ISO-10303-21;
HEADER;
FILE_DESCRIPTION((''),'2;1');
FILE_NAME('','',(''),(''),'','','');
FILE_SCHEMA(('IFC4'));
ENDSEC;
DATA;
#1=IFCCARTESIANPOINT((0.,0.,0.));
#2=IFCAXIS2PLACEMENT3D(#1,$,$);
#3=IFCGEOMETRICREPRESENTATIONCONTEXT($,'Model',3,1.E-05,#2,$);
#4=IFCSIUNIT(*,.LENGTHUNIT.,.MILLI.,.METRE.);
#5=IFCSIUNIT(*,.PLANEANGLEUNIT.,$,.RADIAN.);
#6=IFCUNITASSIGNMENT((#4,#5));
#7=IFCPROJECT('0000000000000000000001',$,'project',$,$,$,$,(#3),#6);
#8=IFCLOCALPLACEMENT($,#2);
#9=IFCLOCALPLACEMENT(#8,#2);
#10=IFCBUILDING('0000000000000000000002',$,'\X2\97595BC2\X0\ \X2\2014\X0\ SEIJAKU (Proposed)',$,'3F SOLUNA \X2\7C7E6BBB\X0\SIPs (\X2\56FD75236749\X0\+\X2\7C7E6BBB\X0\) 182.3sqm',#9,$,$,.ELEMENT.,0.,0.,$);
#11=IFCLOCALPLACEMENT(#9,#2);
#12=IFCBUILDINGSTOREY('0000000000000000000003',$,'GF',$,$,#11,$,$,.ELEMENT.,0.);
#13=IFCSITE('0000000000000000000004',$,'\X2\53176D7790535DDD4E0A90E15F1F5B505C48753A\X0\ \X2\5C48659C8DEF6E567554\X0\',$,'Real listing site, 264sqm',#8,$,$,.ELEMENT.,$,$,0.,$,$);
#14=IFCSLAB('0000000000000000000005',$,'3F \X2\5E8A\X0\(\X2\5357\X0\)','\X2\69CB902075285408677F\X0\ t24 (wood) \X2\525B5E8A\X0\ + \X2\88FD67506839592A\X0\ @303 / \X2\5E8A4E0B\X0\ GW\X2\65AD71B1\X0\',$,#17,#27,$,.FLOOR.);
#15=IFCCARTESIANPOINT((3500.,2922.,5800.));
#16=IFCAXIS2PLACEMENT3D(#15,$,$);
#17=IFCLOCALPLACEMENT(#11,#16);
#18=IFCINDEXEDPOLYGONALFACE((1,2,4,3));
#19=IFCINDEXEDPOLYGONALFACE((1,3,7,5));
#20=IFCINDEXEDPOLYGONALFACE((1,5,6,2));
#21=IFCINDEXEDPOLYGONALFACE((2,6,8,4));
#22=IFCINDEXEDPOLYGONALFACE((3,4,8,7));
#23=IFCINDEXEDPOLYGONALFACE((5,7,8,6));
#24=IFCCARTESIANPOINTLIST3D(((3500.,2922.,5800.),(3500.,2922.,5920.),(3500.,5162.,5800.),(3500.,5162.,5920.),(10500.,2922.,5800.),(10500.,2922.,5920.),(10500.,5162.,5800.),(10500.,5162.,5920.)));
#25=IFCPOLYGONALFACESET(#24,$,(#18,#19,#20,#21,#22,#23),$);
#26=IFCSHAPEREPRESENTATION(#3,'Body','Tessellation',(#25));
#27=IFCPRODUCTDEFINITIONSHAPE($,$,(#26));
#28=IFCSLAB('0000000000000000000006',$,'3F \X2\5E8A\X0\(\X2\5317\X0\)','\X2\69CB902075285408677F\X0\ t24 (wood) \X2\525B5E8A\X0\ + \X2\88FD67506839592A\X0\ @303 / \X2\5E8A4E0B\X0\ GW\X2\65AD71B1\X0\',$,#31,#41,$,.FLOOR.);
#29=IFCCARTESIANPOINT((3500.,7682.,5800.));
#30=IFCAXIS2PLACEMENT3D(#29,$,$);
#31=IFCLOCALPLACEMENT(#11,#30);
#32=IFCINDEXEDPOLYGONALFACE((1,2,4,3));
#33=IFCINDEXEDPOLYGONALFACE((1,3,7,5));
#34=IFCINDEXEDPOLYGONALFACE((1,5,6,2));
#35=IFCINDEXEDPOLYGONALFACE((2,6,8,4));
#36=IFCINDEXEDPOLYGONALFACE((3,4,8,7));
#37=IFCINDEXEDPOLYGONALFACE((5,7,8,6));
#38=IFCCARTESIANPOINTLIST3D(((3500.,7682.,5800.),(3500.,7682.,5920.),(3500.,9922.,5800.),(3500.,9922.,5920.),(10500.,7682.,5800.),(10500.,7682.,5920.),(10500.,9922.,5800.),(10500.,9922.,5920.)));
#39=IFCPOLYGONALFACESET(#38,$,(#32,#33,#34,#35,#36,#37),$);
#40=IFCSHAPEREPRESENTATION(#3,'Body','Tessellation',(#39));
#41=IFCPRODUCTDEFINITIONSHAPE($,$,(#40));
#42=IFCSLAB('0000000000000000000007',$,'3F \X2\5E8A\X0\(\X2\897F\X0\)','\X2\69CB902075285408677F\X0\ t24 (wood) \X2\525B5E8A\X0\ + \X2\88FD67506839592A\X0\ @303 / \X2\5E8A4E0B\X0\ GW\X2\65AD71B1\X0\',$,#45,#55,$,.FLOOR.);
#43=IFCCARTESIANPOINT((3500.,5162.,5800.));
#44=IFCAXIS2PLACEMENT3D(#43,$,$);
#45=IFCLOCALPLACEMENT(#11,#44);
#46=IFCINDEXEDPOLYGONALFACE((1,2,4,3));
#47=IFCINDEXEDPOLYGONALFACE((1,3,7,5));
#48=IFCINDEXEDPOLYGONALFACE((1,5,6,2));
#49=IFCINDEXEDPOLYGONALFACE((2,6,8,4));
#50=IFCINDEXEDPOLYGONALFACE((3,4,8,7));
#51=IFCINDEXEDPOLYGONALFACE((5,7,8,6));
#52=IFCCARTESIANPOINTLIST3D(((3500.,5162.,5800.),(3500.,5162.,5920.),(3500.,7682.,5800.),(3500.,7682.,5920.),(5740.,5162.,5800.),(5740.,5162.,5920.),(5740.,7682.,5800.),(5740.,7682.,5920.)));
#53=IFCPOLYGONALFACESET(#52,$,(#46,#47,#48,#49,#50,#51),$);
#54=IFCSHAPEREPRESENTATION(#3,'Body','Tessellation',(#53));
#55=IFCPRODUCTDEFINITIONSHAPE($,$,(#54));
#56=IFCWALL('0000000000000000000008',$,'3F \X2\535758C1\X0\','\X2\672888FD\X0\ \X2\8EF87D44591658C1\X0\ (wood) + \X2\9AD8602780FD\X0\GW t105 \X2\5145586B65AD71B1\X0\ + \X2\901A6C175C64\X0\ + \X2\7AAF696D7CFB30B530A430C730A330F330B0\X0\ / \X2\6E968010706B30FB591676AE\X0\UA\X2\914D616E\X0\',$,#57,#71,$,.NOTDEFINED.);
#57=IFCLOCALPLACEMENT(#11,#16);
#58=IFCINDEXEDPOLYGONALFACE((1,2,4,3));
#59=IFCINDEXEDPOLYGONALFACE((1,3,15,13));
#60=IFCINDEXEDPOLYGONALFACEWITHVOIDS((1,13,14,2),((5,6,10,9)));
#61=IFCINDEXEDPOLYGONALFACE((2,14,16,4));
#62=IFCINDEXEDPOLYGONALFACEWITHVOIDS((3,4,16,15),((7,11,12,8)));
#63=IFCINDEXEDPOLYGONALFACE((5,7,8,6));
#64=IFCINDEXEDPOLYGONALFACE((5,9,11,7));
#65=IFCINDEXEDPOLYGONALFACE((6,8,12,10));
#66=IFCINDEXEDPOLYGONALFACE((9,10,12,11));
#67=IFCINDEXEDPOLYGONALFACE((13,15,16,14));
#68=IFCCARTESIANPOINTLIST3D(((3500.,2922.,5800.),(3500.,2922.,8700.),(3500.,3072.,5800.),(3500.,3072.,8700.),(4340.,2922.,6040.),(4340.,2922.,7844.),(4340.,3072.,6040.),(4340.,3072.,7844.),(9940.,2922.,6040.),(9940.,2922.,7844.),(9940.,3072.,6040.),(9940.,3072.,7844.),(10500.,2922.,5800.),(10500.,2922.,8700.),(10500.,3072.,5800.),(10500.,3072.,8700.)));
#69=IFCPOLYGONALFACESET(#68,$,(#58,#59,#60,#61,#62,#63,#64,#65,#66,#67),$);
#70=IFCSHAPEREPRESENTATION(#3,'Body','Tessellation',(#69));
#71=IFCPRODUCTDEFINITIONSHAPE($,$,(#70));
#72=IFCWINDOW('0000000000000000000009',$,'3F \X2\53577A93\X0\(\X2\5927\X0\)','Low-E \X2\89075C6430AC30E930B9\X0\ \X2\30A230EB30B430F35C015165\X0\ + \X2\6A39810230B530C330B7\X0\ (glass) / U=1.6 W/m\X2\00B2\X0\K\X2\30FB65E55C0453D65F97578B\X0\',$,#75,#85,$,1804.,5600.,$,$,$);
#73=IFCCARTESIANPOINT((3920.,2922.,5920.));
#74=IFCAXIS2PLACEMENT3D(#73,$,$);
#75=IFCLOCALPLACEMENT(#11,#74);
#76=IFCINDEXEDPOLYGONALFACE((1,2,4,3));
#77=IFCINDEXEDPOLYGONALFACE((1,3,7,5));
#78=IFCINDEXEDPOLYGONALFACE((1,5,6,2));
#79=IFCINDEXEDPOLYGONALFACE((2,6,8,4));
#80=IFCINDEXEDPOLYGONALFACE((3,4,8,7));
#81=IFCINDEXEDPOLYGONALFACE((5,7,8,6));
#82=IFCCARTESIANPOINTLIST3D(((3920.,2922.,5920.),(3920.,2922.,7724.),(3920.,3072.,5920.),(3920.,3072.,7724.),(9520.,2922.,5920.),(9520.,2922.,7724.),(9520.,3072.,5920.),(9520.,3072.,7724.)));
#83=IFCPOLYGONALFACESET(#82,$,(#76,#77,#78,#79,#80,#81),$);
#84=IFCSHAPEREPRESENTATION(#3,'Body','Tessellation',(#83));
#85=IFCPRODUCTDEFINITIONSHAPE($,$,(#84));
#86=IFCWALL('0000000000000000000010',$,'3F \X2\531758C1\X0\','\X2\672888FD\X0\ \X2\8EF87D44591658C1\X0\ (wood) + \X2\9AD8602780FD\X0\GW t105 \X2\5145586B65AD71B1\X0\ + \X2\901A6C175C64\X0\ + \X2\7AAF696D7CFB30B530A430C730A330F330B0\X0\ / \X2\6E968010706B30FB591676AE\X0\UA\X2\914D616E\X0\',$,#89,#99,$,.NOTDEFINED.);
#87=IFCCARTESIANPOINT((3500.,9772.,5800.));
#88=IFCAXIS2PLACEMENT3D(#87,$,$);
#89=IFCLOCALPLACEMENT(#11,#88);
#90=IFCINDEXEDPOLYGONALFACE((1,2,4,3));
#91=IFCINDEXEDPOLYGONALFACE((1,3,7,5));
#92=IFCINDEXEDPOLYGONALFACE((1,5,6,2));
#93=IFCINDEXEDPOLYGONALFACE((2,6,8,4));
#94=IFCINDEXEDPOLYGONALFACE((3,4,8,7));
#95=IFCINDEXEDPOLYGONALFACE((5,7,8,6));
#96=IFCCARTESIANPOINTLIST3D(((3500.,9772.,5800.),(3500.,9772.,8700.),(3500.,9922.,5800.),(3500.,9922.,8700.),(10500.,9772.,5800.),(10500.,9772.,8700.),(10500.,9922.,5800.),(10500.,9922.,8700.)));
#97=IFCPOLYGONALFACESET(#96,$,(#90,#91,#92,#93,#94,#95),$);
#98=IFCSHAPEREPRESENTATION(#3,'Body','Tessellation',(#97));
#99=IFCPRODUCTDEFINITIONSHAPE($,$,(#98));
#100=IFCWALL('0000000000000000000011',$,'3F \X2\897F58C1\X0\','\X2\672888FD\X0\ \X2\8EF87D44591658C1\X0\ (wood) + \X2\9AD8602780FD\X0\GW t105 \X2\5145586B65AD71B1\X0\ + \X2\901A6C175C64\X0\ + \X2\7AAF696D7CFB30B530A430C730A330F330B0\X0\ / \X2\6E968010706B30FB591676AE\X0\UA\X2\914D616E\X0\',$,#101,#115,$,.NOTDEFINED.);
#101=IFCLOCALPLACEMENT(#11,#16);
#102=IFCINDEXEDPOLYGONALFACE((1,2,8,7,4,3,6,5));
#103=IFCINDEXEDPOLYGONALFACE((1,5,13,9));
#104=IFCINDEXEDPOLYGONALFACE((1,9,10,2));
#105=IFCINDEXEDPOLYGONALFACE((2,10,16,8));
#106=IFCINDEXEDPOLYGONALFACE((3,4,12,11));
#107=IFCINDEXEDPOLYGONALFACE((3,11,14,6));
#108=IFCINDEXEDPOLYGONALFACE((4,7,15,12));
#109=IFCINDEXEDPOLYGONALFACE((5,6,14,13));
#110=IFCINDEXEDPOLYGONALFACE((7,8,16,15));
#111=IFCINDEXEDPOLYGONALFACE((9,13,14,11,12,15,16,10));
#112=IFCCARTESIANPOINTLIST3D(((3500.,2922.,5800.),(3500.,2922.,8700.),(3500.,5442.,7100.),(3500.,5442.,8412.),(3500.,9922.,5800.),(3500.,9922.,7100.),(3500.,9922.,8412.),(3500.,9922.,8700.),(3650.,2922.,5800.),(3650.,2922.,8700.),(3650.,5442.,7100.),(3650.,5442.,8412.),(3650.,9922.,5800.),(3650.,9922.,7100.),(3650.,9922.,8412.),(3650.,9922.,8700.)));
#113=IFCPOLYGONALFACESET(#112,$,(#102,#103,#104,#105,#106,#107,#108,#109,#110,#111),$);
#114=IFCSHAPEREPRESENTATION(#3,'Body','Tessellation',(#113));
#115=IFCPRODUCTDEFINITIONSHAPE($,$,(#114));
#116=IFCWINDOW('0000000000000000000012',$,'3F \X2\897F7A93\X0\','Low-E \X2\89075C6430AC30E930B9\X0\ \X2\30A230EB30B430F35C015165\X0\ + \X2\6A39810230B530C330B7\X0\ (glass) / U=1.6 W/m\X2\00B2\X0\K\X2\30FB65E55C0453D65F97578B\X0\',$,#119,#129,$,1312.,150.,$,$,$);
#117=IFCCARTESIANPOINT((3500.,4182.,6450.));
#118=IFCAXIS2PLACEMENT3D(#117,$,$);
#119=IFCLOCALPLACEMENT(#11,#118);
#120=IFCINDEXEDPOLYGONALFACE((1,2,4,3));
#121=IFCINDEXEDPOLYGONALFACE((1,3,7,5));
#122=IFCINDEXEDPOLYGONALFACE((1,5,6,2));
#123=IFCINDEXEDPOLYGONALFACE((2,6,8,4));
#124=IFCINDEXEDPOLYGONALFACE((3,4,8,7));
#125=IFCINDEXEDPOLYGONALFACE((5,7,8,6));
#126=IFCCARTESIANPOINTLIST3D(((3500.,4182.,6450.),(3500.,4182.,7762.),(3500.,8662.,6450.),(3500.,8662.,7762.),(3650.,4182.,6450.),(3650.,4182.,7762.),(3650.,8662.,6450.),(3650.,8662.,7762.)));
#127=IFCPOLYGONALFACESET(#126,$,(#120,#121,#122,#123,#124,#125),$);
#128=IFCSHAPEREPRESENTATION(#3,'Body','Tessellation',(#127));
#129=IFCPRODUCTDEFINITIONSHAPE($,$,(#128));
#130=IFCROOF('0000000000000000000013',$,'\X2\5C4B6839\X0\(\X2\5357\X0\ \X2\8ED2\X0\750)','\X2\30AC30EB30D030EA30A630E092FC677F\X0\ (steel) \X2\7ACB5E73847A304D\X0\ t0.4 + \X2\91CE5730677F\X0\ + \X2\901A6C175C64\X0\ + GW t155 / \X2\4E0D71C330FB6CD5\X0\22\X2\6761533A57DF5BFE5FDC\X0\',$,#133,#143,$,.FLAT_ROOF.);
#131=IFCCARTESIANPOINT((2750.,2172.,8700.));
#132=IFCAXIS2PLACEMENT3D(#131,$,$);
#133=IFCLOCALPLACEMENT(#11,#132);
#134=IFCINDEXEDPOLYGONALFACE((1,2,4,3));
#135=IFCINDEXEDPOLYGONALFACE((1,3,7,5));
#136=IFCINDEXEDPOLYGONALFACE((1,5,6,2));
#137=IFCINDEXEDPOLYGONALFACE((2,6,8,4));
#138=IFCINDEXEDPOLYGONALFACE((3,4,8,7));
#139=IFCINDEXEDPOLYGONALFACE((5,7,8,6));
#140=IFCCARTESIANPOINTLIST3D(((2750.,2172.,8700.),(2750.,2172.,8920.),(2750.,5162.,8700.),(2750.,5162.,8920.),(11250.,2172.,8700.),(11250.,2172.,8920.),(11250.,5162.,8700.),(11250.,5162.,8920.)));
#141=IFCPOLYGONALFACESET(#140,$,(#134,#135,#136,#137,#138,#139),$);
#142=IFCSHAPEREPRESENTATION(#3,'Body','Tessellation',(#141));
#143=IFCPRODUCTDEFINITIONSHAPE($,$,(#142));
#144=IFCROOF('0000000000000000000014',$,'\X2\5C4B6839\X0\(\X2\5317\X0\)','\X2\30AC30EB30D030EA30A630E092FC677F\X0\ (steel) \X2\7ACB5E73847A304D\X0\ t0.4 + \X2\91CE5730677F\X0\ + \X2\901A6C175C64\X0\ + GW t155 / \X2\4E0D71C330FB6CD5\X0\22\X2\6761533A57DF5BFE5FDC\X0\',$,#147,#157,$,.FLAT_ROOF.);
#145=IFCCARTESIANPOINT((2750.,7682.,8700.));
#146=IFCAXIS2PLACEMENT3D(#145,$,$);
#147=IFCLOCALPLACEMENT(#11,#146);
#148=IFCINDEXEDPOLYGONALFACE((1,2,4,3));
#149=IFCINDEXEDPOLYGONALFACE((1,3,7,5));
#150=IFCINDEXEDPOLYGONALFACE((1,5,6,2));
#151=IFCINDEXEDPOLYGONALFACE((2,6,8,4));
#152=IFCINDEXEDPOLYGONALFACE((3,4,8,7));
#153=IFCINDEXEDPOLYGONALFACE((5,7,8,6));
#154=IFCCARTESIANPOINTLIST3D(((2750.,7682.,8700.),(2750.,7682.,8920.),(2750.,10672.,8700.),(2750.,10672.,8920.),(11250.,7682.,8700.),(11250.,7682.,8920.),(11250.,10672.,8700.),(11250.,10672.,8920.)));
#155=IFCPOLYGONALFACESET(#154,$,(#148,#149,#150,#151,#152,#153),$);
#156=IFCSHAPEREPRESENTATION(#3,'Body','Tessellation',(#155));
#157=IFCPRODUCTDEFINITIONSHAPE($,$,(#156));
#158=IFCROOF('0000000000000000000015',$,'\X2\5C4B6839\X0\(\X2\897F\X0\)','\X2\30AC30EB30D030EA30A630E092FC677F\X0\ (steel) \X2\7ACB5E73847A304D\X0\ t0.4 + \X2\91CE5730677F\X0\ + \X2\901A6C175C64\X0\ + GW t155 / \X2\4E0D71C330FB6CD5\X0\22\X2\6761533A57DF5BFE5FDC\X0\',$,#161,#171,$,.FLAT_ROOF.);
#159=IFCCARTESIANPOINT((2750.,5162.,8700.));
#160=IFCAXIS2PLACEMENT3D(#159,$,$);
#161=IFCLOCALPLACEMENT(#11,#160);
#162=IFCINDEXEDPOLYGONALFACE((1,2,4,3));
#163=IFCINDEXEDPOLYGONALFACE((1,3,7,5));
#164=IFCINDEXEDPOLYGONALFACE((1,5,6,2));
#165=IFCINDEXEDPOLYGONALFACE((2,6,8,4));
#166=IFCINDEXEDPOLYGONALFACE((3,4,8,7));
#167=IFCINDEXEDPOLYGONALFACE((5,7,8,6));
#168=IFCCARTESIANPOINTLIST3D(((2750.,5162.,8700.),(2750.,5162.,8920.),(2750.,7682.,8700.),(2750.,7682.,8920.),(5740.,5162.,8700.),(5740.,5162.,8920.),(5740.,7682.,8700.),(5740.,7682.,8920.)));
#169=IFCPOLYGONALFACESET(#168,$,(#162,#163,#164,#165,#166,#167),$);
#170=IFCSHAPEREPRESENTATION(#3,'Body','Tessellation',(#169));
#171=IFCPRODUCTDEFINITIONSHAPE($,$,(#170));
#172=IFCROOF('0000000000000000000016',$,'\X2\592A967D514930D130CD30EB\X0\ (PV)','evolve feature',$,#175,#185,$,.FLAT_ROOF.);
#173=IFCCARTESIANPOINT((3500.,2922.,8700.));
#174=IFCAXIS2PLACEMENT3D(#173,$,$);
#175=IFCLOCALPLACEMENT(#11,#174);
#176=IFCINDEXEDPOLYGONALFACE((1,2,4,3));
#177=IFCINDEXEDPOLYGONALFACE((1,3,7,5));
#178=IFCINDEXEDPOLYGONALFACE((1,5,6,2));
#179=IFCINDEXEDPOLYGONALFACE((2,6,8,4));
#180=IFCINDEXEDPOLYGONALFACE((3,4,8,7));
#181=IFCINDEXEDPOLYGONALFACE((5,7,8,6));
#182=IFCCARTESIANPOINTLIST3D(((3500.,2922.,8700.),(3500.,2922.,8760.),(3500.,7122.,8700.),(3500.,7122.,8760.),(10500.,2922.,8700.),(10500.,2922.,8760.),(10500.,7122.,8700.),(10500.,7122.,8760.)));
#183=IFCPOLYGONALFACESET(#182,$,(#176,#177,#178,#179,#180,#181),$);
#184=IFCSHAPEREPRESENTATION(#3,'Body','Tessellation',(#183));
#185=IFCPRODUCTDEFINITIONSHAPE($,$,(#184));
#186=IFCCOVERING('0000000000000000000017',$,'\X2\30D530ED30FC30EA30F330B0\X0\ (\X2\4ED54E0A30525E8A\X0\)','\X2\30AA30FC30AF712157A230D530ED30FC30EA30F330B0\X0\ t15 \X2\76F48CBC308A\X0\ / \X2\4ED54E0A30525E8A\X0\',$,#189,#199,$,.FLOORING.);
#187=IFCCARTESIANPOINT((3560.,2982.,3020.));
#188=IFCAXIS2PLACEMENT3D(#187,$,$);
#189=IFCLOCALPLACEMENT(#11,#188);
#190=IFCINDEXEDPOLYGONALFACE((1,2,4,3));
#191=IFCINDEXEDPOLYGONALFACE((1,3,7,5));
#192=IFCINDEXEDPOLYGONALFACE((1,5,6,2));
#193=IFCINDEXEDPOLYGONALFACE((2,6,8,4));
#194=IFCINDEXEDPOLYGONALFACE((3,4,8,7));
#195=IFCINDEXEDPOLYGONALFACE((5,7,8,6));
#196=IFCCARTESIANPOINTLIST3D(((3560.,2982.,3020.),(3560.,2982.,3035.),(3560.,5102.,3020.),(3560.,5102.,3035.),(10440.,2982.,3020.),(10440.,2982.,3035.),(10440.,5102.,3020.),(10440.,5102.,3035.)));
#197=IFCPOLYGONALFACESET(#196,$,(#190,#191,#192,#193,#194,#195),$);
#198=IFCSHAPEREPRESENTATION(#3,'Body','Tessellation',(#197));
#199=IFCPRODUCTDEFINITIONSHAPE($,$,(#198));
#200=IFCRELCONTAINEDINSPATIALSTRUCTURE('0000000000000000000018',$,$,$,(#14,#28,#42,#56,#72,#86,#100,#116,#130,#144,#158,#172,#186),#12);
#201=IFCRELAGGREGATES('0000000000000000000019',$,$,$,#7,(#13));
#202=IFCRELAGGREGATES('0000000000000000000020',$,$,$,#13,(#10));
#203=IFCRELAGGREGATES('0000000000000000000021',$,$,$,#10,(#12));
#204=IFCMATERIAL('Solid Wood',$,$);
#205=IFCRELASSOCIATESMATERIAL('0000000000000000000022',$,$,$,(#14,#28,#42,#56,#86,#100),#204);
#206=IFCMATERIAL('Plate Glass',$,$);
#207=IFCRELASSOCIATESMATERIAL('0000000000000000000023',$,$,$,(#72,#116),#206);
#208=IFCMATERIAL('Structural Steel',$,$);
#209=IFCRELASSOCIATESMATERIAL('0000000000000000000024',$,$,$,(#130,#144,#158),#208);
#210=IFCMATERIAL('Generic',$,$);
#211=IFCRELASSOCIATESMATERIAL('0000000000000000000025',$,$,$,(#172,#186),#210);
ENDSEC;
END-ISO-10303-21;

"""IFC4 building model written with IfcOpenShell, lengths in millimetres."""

from ifc_helpers import new_model, si_unit, frame, frame_2d, origin, place, context, project, spatial, rectangle, extrude, material, element, fill, save


model = new_model("IFC4")

# Units and contexts
model_context = context("Model", 3, precision=1e-05, world=origin())
ifc_project = project(units=[si_unit("LENGTHUNIT", "METRE", prefix="MILLI"), si_unit("PLANEANGLEUNIT", "RADIAN")], contexts=[model_context])

# Site, building, storey
site_placement = place(None, origin())
site = spatial("IfcSite", under=ifc_project, at=site_placement, Name="北海道川上郡弟子屈町 屈斜路湖畔", ObjectType="Real listing site, 264sqm", CompositionType="ELEMENT", RefElevation=0.0)
building_placement = place(site_placement, origin())
building = spatial("IfcBuilding", under=site, at=building_placement, Name="静寂 — SEIJAKU (Proposed)", ObjectType="3F SOLUNA 籾殻SIPs (国産杉+籾殻) 182.3sqm", CompositionType="ELEMENT", ElevationOfRefHeight=0.0, ElevationOfTerrain=0.0)
storey_placement = place(building_placement, origin())
storey = spatial("IfcBuildingStorey", under=building, at=storey_placement, Name="GF", CompositionType="ELEMENT", Elevation=0.0)

# Slabs
ifc_material_1 = material(Name="Solid Wood")
slab_1_placement = place(storey_placement, frame((3500.0, 2922.0, 5800.0)))
element("IfcSlab", 1, at=slab_1_placement, inside=storey, material=ifc_material_1, Name="3F 床(南)", Description="構造用合板 t24 (wood) 剛床 + 製材根太 @303 / 床下 GW断熱", PredefinedType="FLOOR", context=model_context, shape_type="SweptSolid", body=[
    extrude(rectangle(XDim=7000.0, YDim=2240.0, at=frame_2d((3500.0, 1120.0))), frame((3500.0, 2922.0, 5800.0)), (0.0, 0.0, 1.0), 120.0),
])
slab_2_placement = place(storey_placement, frame((3500.0, 7682.0, 5800.0)))
element("IfcSlab", 2, at=slab_2_placement, inside=storey, material=ifc_material_1, Name="3F 床(北)", Description="構造用合板 t24 (wood) 剛床 + 製材根太 @303 / 床下 GW断熱", PredefinedType="FLOOR", context=model_context, shape_type="SweptSolid", body=[
    extrude(rectangle(XDim=7000.0, YDim=2240.0, at=frame_2d((3500.0, 1120.0))), frame((3500.0, 7682.0, 5800.0)), (0.0, 0.0, 1.0), 120.0),
])
slab_3_placement = place(storey_placement, frame((3500.0, 5162.0, 5800.0)))
element("IfcSlab", 3, at=slab_3_placement, inside=storey, material=ifc_material_1, Name="3F 床(西)", Description="構造用合板 t24 (wood) 剛床 + 製材根太 @303 / 床下 GW断熱", PredefinedType="FLOOR", context=model_context, shape_type="SweptSolid", body=[
    extrude(rectangle(XDim=2240.0, YDim=2520.0, at=frame_2d((1120.0, 1260.0))), frame((3500.0, 5162.0, 5800.0)), (0.0, 0.0, 1.0), 120.0),
])

# Wall, opening, window
wall_1_placement = place(storey_placement, frame((3500.0, 2922.0, 5800.0)))
wall_1 = element("IfcWall", 4, at=wall_1_placement, inside=storey, material=ifc_material_1, Name="3F 南壁", Description="木製 軸組外壁 (wood) + 高性能GW t105 充填断熱 + 通気層 + 窯業系サイディング / 準耐火・外皮UA配慮", PredefinedType="NOTDEFINED", context=model_context, shape_type="SweptSolid", body=[
    extrude(rectangle(XDim=7000.0, YDim=150.0, at=frame_2d((3500.0, 75.0))), frame((3500.0, 2922.0, 5800.0)), (0.0, 0.0, 1.0), 2900.0),
])
opening_1_placement = place(storey_placement, frame((3920.0, 2922.0, 5920.0)))
opening_1 = element("IfcOpeningElement", 5, at=opening_1_placement, cuts=wall_1, PredefinedType="NOTDEFINED", context=model_context, shape_type="SweptSolid", body=[
    extrude(rectangle(XDim=5600.0, YDim=150.0, at=frame_2d((2800.0, 75.0))), frame((3920.0, 2922.0, 5920.0)), (0.0, 0.0, 1.0), 1804.0),
])
ifc_material_2 = material(Name="Plate Glass")
window_1_placement = place(storey_placement, frame((3920.0, 2922.0, 5920.0)))
window_1 = element("IfcWindow", 6, at=window_1_placement, inside=storey, material=ifc_material_2, Name="3F 南窓(大)", Description="Low-E 複層ガラス アルゴン封入 + 樹脂サッシ (glass) / U=1.6 W/m²K・日射取得型", OverallHeight=1804.0, OverallWidth=5600.0, context=model_context, shape_type="SweptSolid", body=[
    extrude(rectangle(XDim=5600.0, YDim=150.0, at=frame_2d((2800.0, 75.0))), frame((3920.0, 2922.0, 5920.0)), (0.0, 0.0, 1.0), 1804.0),
])
fill(opening_1, window_1)

# Wall
wall_2_placement = place(storey_placement, frame((3500.0, 9772.0, 5800.0)))
element("IfcWall", 7, at=wall_2_placement, inside=storey, material=ifc_material_1, Name="3F 北壁", Description="木製 軸組外壁 (wood) + 高性能GW t105 充填断熱 + 通気層 + 窯業系サイディング / 準耐火・外皮UA配慮", PredefinedType="NOTDEFINED", context=model_context, shape_type="SweptSolid", body=[
    extrude(rectangle(XDim=7000.0, YDim=150.0, at=frame_2d((3500.0, 75.0))), frame((3500.0, 9772.0, 5800.0)), (0.0, 0.0, 1.0), 2900.0),
])

# Wall, opening, window
wall_3_placement = place(storey_placement, frame((3500.0, 2922.0, 5800.0)))
wall_3 = element("IfcWall", 8, at=wall_3_placement, inside=storey, material=ifc_material_1, Name="3F 西壁", Description="木製 軸組外壁 (wood) + 高性能GW t105 充填断熱 + 通気層 + 窯業系サイディング / 準耐火・外皮UA配慮", PredefinedType="NOTDEFINED", context=model_context, shape_type="SweptSolid", body=[
    extrude(rectangle(XDim=150.0, YDim=7000.0, at=frame_2d((75.0, 3500.0))), frame((3500.0, 2922.0, 5800.0)), (0.0, 0.0, 1.0), 2900.0),
])
opening_2_placement = place(storey_placement, frame((3500.0, 4182.0, 6450.0)))
opening_2 = element("IfcOpeningElement", 9, at=opening_2_placement, cuts=wall_3, PredefinedType="NOTDEFINED", context=model_context, shape_type="SweptSolid", body=[
    extrude(rectangle(XDim=150.0, YDim=4480.0, at=frame_2d((75.0, 2240.0))), frame((3500.0, 4182.0, 6450.0)), (0.0, 0.0, 1.0), 1312.0),
])
window_2_placement = place(storey_placement, frame((3500.0, 4182.0, 6450.0)))
window_2 = element("IfcWindow", 10, at=window_2_placement, inside=storey, material=ifc_material_2, Name="3F 西窓", Description="Low-E 複層ガラス アルゴン封入 + 樹脂サッシ (glass) / U=1.6 W/m²K・日射取得型", OverallHeight=1312.0, OverallWidth=150.0, context=model_context, shape_type="SweptSolid", body=[
    extrude(rectangle(XDim=150.0, YDim=4480.0, at=frame_2d((75.0, 2240.0))), frame((3500.0, 4182.0, 6450.0)), (0.0, 0.0, 1.0), 1312.0),
])
fill(opening_2, window_2)

# Roofs
ifc_material_3 = material(Name="Structural Steel")
roof_1_placement = place(storey_placement, frame((2750.0, 2172.0, 8700.0)))
element("IfcRoof", 11, at=roof_1_placement, inside=storey, material=ifc_material_3, Name="屋根(南 軒750)", Description="ガルバリウム鋼板 (steel) 立平葺き t0.4 + 野地板 + 通気層 + GW t155 / 不燃・法22条区域対応", PredefinedType="FLAT_ROOF", context=model_context, shape_type="SweptSolid", body=[
    extrude(rectangle(XDim=8500.0, YDim=2990.0, at=frame_2d((4250.0, 1495.0))), frame((2750.0, 2172.0, 8700.0)), (0.0, 0.0, 1.0), 220.0),
])
roof_2_placement = place(storey_placement, frame((2750.0, 7682.0, 8700.0)))
element("IfcRoof", 12, at=roof_2_placement, inside=storey, material=ifc_material_3, Name="屋根(北)", Description="ガルバリウム鋼板 (steel) 立平葺き t0.4 + 野地板 + 通気層 + GW t155 / 不燃・法22条区域対応", PredefinedType="FLAT_ROOF", context=model_context, shape_type="SweptSolid", body=[
    extrude(rectangle(XDim=8500.0, YDim=2990.0, at=frame_2d((4250.0, 1495.0))), frame((2750.0, 7682.0, 8700.0)), (0.0, 0.0, 1.0), 220.0),
])
roof_3_placement = place(storey_placement, frame((2750.0, 5162.0, 8700.0)))
element("IfcRoof", 13, at=roof_3_placement, inside=storey, material=ifc_material_3, Name="屋根(西)", Description="ガルバリウム鋼板 (steel) 立平葺き t0.4 + 野地板 + 通気層 + GW t155 / 不燃・法22条区域対応", PredefinedType="FLAT_ROOF", context=model_context, shape_type="SweptSolid", body=[
    extrude(rectangle(XDim=2990.0, YDim=2520.0, at=frame_2d((1495.0, 1260.0))), frame((2750.0, 5162.0, 8700.0)), (0.0, 0.0, 1.0), 220.0),
])
ifc_material_4 = material(Name="Generic")
roof_4_placement = place(storey_placement, frame((3500.0, 2922.0, 8700.0)))
element("IfcRoof", 14, at=roof_4_placement, inside=storey, material=ifc_material_4, Name="太陽光パネル (PV)", Description="evolve feature", PredefinedType="FLAT_ROOF", context=model_context, shape_type="SweptSolid", body=[
    extrude(rectangle(XDim=7000.0, YDim=4200.0, at=frame_2d((3500.0, 2100.0))), frame((3500.0, 2922.0, 8700.0)), (0.0, 0.0, 1.0), 60.0),
])

# Covering
covering_1_placement = place(storey_placement, frame((3560.0, 2982.0, 3020.0)))
element("IfcCovering", 15, at=covering_1_placement, inside=storey, material=ifc_material_4, Name="フローリング (仕上げ床)", Description="オーク無垢フローリング t15 直貼り / 仕上げ床", PredefinedType="FLOORING", context=model_context, shape_type="SweptSolid", body=[
    extrude(rectangle(XDim=6880.0, YDim=2120.0, at=frame_2d((3440.0, 1060.0))), frame((3560.0, 2982.0, 3020.0)), (0.0, 0.0, 1.0), 15.0),
])

save(model, "model.ifc")
